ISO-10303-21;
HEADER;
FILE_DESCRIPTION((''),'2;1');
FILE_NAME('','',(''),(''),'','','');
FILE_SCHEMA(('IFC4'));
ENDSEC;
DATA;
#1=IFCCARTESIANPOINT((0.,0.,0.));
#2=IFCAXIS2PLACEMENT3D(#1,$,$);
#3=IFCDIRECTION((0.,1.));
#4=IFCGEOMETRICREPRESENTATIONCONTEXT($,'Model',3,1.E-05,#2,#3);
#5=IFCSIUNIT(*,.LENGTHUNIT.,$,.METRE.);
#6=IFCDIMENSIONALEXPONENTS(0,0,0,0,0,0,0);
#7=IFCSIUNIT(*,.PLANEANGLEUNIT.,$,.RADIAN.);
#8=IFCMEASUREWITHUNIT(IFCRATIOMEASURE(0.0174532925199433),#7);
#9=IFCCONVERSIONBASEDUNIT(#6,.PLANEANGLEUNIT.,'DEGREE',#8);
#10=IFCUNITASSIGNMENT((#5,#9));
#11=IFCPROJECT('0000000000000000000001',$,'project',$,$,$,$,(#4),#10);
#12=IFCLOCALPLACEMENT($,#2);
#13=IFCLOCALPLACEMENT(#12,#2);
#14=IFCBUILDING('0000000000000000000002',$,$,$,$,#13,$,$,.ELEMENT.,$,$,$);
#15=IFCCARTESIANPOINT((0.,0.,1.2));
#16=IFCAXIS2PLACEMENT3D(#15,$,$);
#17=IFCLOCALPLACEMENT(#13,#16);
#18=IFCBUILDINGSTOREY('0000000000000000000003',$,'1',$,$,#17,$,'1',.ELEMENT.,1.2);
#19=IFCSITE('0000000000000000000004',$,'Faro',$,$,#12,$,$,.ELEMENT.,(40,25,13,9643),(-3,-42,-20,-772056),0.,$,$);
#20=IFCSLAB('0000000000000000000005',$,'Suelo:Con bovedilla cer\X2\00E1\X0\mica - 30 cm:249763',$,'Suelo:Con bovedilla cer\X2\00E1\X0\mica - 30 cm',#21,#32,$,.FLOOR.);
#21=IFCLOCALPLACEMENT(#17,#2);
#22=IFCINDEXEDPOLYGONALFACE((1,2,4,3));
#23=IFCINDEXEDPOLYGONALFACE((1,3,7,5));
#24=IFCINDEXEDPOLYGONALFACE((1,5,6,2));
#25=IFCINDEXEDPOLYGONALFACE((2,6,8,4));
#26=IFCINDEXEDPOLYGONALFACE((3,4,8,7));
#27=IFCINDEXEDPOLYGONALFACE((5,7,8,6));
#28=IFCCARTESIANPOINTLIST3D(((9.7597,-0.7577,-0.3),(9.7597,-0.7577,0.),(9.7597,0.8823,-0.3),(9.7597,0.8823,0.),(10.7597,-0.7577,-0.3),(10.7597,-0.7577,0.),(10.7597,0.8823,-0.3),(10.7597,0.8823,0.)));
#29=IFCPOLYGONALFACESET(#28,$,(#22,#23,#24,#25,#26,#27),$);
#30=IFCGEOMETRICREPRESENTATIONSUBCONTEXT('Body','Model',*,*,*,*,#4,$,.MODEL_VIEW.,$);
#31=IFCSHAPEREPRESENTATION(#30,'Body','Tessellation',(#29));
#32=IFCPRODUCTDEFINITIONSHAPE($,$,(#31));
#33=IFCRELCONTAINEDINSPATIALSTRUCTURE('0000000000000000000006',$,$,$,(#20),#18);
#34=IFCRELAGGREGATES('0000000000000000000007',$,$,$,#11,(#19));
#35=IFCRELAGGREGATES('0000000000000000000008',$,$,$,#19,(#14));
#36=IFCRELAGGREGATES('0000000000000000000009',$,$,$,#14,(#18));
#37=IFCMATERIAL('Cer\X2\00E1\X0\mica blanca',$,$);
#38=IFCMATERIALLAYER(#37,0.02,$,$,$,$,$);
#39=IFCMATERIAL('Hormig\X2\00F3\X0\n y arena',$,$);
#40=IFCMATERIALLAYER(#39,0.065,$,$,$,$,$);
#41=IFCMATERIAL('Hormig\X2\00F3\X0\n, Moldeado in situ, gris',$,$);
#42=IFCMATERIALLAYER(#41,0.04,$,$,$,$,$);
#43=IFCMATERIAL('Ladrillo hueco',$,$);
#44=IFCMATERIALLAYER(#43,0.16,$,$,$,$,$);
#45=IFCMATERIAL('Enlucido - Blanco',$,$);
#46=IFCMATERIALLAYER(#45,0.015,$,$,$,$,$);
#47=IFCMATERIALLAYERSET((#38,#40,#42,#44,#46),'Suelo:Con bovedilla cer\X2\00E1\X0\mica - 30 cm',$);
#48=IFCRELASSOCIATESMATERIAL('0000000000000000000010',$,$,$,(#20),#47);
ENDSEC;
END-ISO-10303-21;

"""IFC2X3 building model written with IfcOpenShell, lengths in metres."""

from ifc_helpers import new_model, entity, si_unit, converted_unit, direction, frame, origin, origin_2d_with_axis, place, context, subcontext, project, spatial, rectangle, extrude, material, layer, layer_set, layer_usage, element, save


model = new_model("IFC2X3")

# Units and contexts
model_context = context("Model", 3, precision=1e-05, world=origin(), true_north=direction((0.0, 1.0)))
body_context = subcontext(model_context, "Body", "Model", "MODEL_VIEW")
ifc_project = project(units=[si_unit("LENGTHUNIT", "METRE"), converted_unit("PLANEANGLEUNIT", "DEGREE", entity("IfcRatioMeasure", 0.0174532925199433), si_unit("PLANEANGLEUNIT", "RADIAN"), dimensions=[0, 0, 0, 0, 0, 0, 0])], contexts=[model_context])

# Site, building, storey
site_placement = place(None, origin())
site = spatial("IfcSite", under=ifc_project, at=site_placement, Name="Faro", CompositionType="ELEMENT", RefLatitude=(40, 25, 13, 9643), RefLongitude=(-3, -42, -20, -772056), RefElevation=0.0)
building_placement = place(site_placement, origin())
building = spatial("IfcBuilding", under=site, at=building_placement, CompositionType="ELEMENT")
storey_placement = place(building_placement, frame((0.0, 0.0, 1.2)))
storey = spatial("IfcBuildingStorey", under=building, at=storey_placement, Name="1", LongName="1", CompositionType="ELEMENT", Elevation=1.2)

# Slab
ifc_material_1 = material(Name="Cerámica blanca")
ifc_layer_1 = layer(ifc_material_1, 0.02)
ifc_material_2 = material(Name="Hormigón y arena")
ifc_layer_2 = layer(ifc_material_2, 0.065)
ifc_material_3 = material(Name="Hormigón, Moldeado in situ, gris")
ifc_layer_3 = layer(ifc_material_3, 0.04)
ifc_material_4 = material(Name="Ladrillo hueco")
ifc_layer_4 = layer(ifc_material_4, 0.16)
ifc_material_5 = material(Name="Enlucido - Blanco")
ifc_layer_5 = layer(ifc_material_5, 0.015)
ifc_layer_set = layer_set([ifc_layer_1, ifc_layer_2, ifc_layer_3, ifc_layer_4, ifc_layer_5], Name="Suelo:Con bovedilla cerámica - 30 cm")
ifc_layer_usage = layer_usage(ifc_layer_set, "AXIS3", "POSITIVE", 0.0)
slab_placement = place(storey_placement, origin())
element("IfcSlab", 1, at=slab_placement, inside=storey, material=ifc_layer_usage, Name="Suelo:Con bovedilla cerámica - 30 cm:249763", ObjectType="Suelo:Con bovedilla cerámica - 30 cm", PredefinedType="FLOOR", context=body_context, shape_type="SweptSolid", body=[
    extrude(rectangle(XDim=1.64, YDim=1.0, at=origin_2d_with_axis()), frame((10.2597, 0.0623, 0.0), z_axis=(0.0, 0.0, -1.0), x_axis=(0.0, 1.0, 0.0)), (0.0, 0.0, 1.0), 0.3),
])

save(model, "model.ifc")
